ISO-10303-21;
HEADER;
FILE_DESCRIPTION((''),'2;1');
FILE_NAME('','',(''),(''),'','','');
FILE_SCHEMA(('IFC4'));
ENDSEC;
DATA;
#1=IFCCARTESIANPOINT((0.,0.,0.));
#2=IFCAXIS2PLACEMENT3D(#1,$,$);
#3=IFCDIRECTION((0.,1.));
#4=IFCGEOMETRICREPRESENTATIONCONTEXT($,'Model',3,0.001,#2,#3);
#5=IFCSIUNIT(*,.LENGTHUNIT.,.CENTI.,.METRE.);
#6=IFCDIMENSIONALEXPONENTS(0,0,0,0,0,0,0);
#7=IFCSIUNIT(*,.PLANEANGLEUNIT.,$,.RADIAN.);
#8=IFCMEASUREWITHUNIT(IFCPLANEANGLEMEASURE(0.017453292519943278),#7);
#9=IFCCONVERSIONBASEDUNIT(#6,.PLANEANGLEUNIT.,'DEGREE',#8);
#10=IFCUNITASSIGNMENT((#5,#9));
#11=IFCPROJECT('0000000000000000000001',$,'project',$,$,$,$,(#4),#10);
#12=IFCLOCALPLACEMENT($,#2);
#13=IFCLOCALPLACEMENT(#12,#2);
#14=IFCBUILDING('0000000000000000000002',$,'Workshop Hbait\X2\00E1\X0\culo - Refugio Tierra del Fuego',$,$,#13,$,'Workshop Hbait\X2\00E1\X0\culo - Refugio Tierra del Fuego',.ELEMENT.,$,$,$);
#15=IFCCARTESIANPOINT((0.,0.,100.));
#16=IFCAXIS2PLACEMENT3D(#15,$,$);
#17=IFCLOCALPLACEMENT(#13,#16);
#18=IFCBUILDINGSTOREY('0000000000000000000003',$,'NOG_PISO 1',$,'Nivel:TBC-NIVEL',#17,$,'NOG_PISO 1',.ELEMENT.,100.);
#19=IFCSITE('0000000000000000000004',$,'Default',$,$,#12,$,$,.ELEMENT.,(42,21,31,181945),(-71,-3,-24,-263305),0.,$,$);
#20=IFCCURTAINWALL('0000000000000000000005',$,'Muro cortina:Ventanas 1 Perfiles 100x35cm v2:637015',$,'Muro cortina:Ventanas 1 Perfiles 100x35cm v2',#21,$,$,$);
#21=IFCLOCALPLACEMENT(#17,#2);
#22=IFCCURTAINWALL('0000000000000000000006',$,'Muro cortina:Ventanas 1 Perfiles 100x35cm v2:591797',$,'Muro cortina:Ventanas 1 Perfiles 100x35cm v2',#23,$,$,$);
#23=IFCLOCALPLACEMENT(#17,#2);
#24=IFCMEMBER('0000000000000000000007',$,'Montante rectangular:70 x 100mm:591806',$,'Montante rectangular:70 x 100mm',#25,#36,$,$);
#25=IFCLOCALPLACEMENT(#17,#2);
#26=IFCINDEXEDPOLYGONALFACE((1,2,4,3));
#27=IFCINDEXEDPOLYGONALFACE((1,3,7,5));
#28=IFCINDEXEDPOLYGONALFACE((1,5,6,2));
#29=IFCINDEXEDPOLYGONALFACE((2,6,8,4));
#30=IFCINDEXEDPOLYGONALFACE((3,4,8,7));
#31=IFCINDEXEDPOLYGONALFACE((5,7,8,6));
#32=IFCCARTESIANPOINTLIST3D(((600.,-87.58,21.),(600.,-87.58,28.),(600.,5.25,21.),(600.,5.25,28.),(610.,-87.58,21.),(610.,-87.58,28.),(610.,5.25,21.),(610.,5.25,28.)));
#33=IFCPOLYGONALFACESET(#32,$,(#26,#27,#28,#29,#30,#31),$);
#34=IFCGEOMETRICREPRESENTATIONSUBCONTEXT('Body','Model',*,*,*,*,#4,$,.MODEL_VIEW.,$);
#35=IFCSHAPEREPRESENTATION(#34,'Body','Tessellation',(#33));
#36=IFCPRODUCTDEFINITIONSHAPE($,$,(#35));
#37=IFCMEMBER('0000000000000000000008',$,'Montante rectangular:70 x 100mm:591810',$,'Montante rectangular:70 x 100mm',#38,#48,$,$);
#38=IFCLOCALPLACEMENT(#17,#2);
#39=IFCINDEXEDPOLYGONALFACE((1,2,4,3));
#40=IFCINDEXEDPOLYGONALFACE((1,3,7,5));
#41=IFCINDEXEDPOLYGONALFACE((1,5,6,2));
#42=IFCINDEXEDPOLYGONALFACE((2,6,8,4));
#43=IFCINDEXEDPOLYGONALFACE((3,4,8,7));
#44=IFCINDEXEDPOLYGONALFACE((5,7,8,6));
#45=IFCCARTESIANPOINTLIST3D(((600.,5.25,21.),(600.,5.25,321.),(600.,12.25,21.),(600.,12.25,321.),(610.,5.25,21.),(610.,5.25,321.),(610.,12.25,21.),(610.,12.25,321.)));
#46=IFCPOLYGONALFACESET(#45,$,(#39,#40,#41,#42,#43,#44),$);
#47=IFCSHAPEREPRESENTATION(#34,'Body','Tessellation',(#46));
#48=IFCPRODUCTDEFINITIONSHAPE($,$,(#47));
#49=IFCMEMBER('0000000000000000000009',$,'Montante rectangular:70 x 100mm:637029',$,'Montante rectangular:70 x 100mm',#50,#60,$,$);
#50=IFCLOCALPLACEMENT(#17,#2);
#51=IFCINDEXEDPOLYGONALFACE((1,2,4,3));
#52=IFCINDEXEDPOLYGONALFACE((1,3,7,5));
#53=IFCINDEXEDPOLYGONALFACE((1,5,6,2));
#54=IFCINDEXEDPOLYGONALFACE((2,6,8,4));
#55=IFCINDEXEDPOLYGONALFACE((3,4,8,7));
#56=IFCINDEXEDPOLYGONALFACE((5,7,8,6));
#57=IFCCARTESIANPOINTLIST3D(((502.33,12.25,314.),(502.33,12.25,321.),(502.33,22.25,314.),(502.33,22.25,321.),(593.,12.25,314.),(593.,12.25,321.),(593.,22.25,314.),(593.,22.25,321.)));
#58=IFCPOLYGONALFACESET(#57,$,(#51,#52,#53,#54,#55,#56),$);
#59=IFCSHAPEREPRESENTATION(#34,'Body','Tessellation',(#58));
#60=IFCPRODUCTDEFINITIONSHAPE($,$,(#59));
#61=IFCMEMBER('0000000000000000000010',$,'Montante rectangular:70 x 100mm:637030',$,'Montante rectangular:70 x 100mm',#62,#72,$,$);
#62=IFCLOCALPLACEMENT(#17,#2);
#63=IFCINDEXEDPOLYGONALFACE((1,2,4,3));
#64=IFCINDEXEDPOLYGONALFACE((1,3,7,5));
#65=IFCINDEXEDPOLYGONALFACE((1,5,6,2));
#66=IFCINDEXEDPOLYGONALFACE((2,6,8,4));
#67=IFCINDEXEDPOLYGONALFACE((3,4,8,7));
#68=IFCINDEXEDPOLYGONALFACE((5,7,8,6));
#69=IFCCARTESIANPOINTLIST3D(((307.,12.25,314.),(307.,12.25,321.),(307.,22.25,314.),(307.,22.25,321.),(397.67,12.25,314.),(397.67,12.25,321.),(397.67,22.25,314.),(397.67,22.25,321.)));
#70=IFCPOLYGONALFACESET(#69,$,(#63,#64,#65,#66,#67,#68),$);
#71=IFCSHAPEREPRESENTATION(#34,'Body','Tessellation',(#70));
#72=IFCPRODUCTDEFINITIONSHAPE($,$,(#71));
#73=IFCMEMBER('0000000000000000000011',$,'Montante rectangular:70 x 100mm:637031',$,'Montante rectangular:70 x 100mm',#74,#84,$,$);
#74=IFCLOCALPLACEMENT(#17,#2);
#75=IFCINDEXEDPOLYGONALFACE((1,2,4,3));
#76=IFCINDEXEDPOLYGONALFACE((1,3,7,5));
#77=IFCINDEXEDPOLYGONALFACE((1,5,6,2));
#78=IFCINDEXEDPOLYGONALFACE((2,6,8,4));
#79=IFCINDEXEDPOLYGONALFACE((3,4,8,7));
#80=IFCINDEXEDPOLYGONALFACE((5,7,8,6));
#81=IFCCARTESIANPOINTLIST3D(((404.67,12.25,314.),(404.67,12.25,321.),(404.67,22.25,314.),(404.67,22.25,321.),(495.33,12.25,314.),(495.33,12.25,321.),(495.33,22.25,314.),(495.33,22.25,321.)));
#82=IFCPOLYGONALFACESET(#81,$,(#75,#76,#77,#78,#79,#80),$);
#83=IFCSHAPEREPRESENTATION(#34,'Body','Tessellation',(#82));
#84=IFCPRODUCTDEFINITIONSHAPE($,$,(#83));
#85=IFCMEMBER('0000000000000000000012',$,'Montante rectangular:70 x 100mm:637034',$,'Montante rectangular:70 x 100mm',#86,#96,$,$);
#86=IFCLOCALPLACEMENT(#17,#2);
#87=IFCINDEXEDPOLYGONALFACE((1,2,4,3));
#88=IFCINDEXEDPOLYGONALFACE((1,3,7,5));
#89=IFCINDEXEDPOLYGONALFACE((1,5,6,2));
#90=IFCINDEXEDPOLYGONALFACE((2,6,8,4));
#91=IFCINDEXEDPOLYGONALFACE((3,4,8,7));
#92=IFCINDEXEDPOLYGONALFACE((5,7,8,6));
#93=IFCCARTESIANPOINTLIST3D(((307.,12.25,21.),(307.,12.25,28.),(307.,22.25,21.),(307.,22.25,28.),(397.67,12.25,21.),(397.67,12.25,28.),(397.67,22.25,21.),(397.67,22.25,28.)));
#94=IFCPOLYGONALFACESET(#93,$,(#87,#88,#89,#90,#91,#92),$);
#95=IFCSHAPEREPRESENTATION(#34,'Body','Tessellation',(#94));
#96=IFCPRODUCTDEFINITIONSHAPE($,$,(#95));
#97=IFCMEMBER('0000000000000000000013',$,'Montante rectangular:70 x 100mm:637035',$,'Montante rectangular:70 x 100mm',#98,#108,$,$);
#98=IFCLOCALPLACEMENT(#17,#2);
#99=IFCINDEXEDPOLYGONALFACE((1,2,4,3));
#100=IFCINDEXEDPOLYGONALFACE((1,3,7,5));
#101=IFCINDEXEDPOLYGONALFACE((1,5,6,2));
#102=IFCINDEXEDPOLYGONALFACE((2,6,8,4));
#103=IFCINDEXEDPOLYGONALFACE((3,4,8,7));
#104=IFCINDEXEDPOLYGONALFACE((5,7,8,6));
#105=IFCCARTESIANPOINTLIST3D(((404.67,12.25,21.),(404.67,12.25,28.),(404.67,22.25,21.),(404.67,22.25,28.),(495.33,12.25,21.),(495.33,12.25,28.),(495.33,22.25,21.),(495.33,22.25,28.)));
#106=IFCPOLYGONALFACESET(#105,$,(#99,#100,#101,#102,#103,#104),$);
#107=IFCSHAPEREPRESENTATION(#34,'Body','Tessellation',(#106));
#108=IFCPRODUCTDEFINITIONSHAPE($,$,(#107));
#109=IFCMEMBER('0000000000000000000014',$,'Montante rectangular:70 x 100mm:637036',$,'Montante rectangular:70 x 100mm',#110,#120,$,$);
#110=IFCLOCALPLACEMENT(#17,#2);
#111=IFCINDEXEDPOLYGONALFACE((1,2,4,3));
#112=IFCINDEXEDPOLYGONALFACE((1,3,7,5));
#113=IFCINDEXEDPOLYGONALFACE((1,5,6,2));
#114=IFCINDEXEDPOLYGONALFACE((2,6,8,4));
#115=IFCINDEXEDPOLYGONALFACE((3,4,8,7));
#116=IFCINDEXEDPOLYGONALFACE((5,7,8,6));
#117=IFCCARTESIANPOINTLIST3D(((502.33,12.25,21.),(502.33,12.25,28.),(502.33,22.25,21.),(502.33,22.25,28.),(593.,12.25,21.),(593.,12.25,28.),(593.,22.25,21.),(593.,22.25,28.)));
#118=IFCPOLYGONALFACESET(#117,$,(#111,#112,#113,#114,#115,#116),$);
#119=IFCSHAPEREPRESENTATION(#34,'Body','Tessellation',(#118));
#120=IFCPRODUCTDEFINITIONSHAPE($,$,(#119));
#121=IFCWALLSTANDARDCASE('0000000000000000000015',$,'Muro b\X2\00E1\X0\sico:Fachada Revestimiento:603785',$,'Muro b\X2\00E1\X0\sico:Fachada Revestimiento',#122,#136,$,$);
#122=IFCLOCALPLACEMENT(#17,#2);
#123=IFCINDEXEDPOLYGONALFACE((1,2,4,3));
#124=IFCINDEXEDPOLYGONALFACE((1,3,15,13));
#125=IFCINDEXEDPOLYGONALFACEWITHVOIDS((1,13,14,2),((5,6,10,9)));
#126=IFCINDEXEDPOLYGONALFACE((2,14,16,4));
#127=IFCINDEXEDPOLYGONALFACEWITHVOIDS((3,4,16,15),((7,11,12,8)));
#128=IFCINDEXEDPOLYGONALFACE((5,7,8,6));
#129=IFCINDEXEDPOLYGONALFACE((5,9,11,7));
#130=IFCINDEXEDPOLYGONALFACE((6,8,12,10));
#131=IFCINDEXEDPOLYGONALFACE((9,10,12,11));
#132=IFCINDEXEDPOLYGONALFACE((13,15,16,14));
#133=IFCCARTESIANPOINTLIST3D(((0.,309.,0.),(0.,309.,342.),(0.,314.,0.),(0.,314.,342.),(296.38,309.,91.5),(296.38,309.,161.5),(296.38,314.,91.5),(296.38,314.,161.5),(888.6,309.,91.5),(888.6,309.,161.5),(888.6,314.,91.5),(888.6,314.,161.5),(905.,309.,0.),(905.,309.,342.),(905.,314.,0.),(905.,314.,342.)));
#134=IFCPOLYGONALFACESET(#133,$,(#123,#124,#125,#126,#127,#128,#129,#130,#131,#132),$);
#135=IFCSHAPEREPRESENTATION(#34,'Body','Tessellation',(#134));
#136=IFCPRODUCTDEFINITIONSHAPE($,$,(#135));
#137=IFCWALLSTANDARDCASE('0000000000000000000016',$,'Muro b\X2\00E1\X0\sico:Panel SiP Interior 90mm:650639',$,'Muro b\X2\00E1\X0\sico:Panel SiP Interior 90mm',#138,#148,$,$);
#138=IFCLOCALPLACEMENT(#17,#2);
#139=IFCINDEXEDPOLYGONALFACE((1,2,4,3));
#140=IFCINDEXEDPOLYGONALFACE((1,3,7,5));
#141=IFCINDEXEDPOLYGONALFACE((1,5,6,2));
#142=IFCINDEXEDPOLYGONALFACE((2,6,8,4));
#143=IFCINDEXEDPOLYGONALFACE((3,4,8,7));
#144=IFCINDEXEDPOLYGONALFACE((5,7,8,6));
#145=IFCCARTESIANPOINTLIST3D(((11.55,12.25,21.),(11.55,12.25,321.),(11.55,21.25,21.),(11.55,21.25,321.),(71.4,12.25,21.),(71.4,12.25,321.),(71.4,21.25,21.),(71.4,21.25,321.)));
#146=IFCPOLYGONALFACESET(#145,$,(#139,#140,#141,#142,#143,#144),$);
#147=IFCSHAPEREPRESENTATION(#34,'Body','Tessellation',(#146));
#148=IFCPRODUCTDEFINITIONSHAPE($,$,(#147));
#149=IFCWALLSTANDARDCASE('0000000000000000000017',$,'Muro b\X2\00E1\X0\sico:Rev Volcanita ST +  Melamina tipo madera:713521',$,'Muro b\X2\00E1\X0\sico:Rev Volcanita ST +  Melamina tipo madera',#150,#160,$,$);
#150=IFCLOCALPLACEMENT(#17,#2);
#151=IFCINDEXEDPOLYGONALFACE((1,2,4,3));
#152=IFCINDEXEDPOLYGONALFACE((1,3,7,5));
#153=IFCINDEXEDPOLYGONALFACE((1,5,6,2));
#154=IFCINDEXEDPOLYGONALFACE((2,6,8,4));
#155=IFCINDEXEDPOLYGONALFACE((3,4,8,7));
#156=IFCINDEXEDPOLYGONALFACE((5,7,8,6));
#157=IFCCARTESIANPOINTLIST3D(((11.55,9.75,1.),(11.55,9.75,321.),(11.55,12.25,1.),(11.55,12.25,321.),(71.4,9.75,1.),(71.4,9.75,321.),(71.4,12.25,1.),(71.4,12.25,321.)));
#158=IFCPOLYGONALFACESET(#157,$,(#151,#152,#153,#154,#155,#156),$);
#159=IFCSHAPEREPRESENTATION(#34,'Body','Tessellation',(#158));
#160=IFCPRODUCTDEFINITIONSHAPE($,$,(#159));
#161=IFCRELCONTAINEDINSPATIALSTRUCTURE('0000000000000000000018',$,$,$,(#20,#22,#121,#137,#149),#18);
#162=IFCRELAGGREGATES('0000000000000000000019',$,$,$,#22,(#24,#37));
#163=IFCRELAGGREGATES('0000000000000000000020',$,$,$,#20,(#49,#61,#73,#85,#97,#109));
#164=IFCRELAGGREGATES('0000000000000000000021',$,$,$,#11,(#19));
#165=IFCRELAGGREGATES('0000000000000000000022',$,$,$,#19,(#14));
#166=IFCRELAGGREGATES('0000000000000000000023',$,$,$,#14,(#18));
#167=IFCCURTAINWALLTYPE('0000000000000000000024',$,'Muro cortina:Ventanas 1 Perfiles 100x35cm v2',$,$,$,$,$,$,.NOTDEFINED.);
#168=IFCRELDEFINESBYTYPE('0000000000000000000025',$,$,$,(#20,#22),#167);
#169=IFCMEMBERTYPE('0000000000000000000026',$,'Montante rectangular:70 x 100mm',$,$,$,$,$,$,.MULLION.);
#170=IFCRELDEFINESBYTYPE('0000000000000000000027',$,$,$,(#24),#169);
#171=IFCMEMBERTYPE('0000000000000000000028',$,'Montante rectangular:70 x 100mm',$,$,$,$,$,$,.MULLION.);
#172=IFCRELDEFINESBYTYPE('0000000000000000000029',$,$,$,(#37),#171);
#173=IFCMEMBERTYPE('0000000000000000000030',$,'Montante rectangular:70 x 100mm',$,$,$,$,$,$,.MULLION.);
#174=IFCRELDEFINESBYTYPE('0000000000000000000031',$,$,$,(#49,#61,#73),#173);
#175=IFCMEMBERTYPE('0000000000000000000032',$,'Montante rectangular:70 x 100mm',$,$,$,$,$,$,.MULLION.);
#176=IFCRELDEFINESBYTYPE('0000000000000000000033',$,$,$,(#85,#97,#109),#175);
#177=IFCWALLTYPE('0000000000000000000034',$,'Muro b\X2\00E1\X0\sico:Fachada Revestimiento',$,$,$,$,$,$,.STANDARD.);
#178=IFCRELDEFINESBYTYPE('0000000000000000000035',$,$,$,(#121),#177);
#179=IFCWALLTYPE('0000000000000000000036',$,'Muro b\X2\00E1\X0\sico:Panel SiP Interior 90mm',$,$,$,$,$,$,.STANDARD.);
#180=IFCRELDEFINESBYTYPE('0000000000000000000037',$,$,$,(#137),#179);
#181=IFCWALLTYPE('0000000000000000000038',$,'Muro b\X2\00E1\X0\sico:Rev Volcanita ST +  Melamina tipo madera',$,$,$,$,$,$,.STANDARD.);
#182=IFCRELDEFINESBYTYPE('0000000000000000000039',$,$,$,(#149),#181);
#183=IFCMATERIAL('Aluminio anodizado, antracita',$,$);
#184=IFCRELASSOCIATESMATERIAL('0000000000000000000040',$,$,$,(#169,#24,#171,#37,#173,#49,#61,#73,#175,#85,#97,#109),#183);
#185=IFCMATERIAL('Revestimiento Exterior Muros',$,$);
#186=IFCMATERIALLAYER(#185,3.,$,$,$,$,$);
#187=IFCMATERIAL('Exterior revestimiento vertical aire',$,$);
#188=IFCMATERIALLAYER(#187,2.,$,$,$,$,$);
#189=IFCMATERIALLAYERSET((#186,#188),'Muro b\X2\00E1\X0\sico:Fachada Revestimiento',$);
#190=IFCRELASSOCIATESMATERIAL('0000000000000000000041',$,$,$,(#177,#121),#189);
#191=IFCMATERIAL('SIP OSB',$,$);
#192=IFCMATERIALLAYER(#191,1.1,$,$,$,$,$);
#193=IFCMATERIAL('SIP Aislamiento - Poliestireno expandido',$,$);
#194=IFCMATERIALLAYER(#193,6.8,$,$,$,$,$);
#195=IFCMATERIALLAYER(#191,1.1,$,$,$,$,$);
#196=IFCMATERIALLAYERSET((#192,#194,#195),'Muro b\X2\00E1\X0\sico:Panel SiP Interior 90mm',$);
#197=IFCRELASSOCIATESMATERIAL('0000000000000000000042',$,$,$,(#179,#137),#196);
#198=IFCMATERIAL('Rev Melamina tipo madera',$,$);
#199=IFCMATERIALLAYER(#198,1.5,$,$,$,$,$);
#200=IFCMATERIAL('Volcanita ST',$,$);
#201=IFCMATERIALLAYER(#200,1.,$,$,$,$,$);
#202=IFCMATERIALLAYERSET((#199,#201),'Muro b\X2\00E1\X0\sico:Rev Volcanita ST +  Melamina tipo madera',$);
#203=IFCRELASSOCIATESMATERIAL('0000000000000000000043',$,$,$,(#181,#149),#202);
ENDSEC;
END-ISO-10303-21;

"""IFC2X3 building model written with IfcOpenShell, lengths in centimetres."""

from ifc_helpers import new_model, entity, si_unit, converted_unit, direction, frame, frame_2d, origin, origin_2d_with_axis, place, context, subcontext, project, spatial, rectangle, extrude, source, transform, mapped, material, layer, layer_set, layer_usage, type_object, type_shapes, element, aggregate, save


model = new_model("IFC2X3")

# Units and contexts
model_context = context("Model", 3, precision=0.001, world=origin(), true_north=direction((0.0, 1.0)))
body_context = subcontext(model_context, "Body", "Model", "MODEL_VIEW")
ifc_project = project(units=[si_unit("LENGTHUNIT", "METRE", prefix="CENTI"), converted_unit("PLANEANGLEUNIT", "DEGREE", entity("IfcPlaneAngleMeasure", 0.017453292519943278), si_unit("PLANEANGLEUNIT", "RADIAN"), dimensions=[0, 0, 0, 0, 0, 0, 0])], contexts=[model_context])

# Site, building, storey
site_placement = place(None, origin())
site = spatial("IfcSite", under=ifc_project, at=site_placement, Name="Default", CompositionType="ELEMENT", RefLatitude=(42, 21, 31, 181945), RefLongitude=(-71, -3, -24, -263305), RefElevation=0.0)
building_placement = place(site_placement, origin())
building = spatial("IfcBuilding", under=site, at=building_placement, Name="Workshop Hbaitáculo - Refugio Tierra del Fuego", LongName="Workshop Hbaitáculo - Refugio Tierra del Fuego", CompositionType="ELEMENT")
storey_placement = place(building_placement, frame((0.0, 0.0, 100.0)))
storey = spatial("IfcBuildingStorey", under=building, at=storey_placement, Name="NOG_PISO 1", ObjectType="Nivel:TBC-NIVEL", LongName="NOG_PISO 1", CompositionType="ELEMENT", Elevation=100.0)

# Curtain wall
curtain_wall_type = type_object("IfcCurtainWallType", Name="Muro cortina:Ventanas 1 Perfiles 100x35cm v2", PredefinedType="NOTDEFINED")
ifc_material_1 = material(Name="Aluminio anodizado, antracita")
curtain_wall_1_placement = place(storey_placement, frame((0.0, 0.0, -100.0)))
curtain_wall_1 = element("IfcCurtainWall", 1, at=curtain_wall_1_placement, inside=storey, type_object=curtain_wall_type, Name="Muro cortina:Ventanas 1 Perfiles 100x35cm v2:637015", ObjectType="Muro cortina:Ventanas 1 Perfiles 100x35cm v2")

# Curtain wall, members
curtain_wall_2_placement = place(storey_placement, frame((0.0, 0.0, -100.0)))
curtain_wall_2 = element("IfcCurtainWall", 2, at=curtain_wall_2_placement, inside=storey, type_object=curtain_wall_type, Name="Muro cortina:Ventanas 1 Perfiles 100x35cm v2:591797", ObjectType="Muro cortina:Ventanas 1 Perfiles 100x35cm v2")
member_type_1 = type_object("IfcMemberType", Name="Montante rectangular:70 x 100mm", PredefinedType="MULLION", material=ifc_material_1)
shared_shape_1 = source(origin(), body_context, "Body", "SweptSolid", [
    extrude(rectangle(XDim=7.0, YDim=10.0, at=origin_2d_with_axis()), frame((-3.5, 0.0, -92.83), z_axis=(0.0, 0.0, 1.0), x_axis=(-1.0, 0.0, 0.0)), (0.0, 0.0, 1.0), 92.83),
])
type_shapes(member_type_1, [shared_shape_1])
member_1_placement = place(curtain_wall_2_placement, frame((605.0, 5.25, 121.0), z_axis=(0.0, 1.0, 0.0), x_axis=(0.0, 0.0, -1.0)))
member_1 = element("IfcMember", 3, at=member_1_placement, type_object=member_type_1, material=ifc_material_1, Name="Montante rectangular:70 x 100mm:591806", ObjectType="Montante rectangular:70 x 100mm", context=body_context, shape_type="MappedRepresentation", body=[
    mapped(shared_shape_1, transform((0.0, 0.0, 0.0), scale=1.0)),
])
member_type_2 = type_object("IfcMemberType", Name="Montante rectangular:70 x 100mm", PredefinedType="MULLION", material=ifc_material_1)
shared_shape_2 = source(origin(), body_context, "Body", "SweptSolid", [
    extrude(rectangle(XDim=7.0, YDim=10.0, at=origin_2d_with_axis()), frame((-3.5, 0.0, -300.0), z_axis=(0.0, 0.0, 1.0), x_axis=(-1.0, 0.0, 0.0)), (0.0, 0.0, 1.0), 300.0),
])
type_shapes(member_type_2, [shared_shape_2])
member_2_placement = place(curtain_wall_2_placement, frame((605.0, 12.25, 421.0), z_axis=(0.0, 0.0, 1.0), x_axis=(0.0, 1.0, 0.0)))
member_2 = element("IfcMember", 4, at=member_2_placement, type_object=member_type_2, material=ifc_material_1, Name="Montante rectangular:70 x 100mm:591810", ObjectType="Montante rectangular:70 x 100mm", context=body_context, shape_type="MappedRepresentation", body=[
    mapped(shared_shape_2, transform((0.0, 0.0, 0.0), scale=1.0)),
])

# Members
member_type_3 = type_object("IfcMemberType", Name="Montante rectangular:70 x 100mm", PredefinedType="MULLION", material=ifc_material_1)
shared_shape_3 = source(origin(), body_context, "Body", "SweptSolid", [
    extrude(rectangle(XDim=7.0, YDim=10.0, at=origin_2d_with_axis()), frame((-3.5, 0.0, -90.67), z_axis=(0.0, 0.0, 1.0), x_axis=(-1.0, 0.0, 0.0)), (0.0, 0.0, 1.0), 90.67),
])
type_shapes(member_type_3, [shared_shape_3])
member_3_placement = place(curtain_wall_1_placement, frame((593.0, 17.25, 421.0), z_axis=(1.0, 0.0, 0.0), x_axis=(0.0, 0.0, 1.0)))
member_3 = element("IfcMember", 5, at=member_3_placement, type_object=member_type_3, material=ifc_material_1, Name="Montante rectangular:70 x 100mm:637029", ObjectType="Montante rectangular:70 x 100mm", context=body_context, shape_type="MappedRepresentation", body=[
    mapped(shared_shape_3, transform((0.0, 0.0, 0.0), scale=1.0)),
])
member_4_placement = place(curtain_wall_1_placement, frame((397.67, 17.25, 421.0), z_axis=(1.0, 0.0, 0.0), x_axis=(0.0, 0.0, 1.0)))
member_4 = element("IfcMember", 6, at=member_4_placement, type_object=member_type_3, material=ifc_material_1, Name="Montante rectangular:70 x 100mm:637030", ObjectType="Montante rectangular:70 x 100mm", context=body_context, shape_type="MappedRepresentation", body=[
    mapped(shared_shape_3, transform((0.0, 0.0, 0.0), scale=1.0)),
])
member_5_placement = place(curtain_wall_1_placement, frame((495.33, 17.25, 421.0), z_axis=(1.0, 0.0, 0.0), x_axis=(0.0, 0.0, 1.0)))
member_5 = element("IfcMember", 7, at=member_5_placement, type_object=member_type_3, material=ifc_material_1, Name="Montante rectangular:70 x 100mm:637031", ObjectType="Montante rectangular:70 x 100mm", context=body_context, shape_type="MappedRepresentation", body=[
    mapped(shared_shape_3, transform((0.0, 0.0, 0.0), scale=1.0)),
])
member_type_4 = type_object("IfcMemberType", Name="Montante rectangular:70 x 100mm", PredefinedType="MULLION", material=ifc_material_1)
shared_shape_4 = source(origin(), body_context, "Body", "SweptSolid", [
    extrude(rectangle(XDim=7.0, YDim=10.0, at=origin_2d_with_axis()), frame((-3.5, 0.0, -90.67), z_axis=(0.0, 0.0, 1.0), x_axis=(-1.0, 0.0, 0.0)), (0.0, 0.0, 1.0), 90.67),
])
type_shapes(member_type_4, [shared_shape_4])
member_6_placement = place(curtain_wall_1_placement, frame((307.0, 17.25, 121.0), z_axis=(-1.0, 0.0, 0.0), x_axis=(0.0, 0.0, -1.0)))
member_6 = element("IfcMember", 8, at=member_6_placement, type_object=member_type_4, material=ifc_material_1, Name="Montante rectangular:70 x 100mm:637034", ObjectType="Montante rectangular:70 x 100mm", context=body_context, shape_type="MappedRepresentation", body=[
    mapped(shared_shape_4, transform((0.0, 0.0, 0.0), scale=1.0)),
])
member_7_placement = place(curtain_wall_1_placement, frame((404.67, 17.25, 121.0), z_axis=(-1.0, 0.0, 0.0), x_axis=(0.0, 0.0, -1.0)))
member_7 = element("IfcMember", 9, at=member_7_placement, type_object=member_type_4, material=ifc_material_1, Name="Montante rectangular:70 x 100mm:637035", ObjectType="Montante rectangular:70 x 100mm", context=body_context, shape_type="MappedRepresentation", body=[
    mapped(shared_shape_4, transform((0.0, 0.0, 0.0), scale=1.0)),
])
member_8_placement = place(curtain_wall_1_placement, frame((502.33, 17.25, 121.0), z_axis=(-1.0, 0.0, 0.0), x_axis=(0.0, 0.0, -1.0)))
member_8 = element("IfcMember", 10, at=member_8_placement, type_object=member_type_4, material=ifc_material_1, Name="Montante rectangular:70 x 100mm:637036", ObjectType="Montante rectangular:70 x 100mm", context=body_context, shape_type="MappedRepresentation", body=[
    mapped(shared_shape_4, transform((0.0, 0.0, 0.0), scale=1.0)),
])

aggregate(curtain_wall_2, [member_1, member_2])
aggregate(curtain_wall_1, [member_3, member_4, member_5, member_6, member_7, member_8])

# Wall, opening
ifc_material_2 = material(Name="Revestimiento Exterior Muros")
ifc_layer_1 = layer(ifc_material_2, 3.0)
ifc_material_3 = material(Name="Exterior revestimiento vertical aire")
ifc_layer_2 = layer(ifc_material_3, 2.0)
ifc_layer_set_1 = layer_set([ifc_layer_1, ifc_layer_2], Name="Muro básico:Fachada Revestimiento")
ifc_layer_usage_1 = layer_usage(ifc_layer_set_1, "AXIS2", "POSITIVE", -2.5)
wall_type_1 = type_object("IfcWallType", Name="Muro básico:Fachada Revestimiento", PredefinedType="STANDARD", material=ifc_layer_set_1)
wall_1_placement = place(storey_placement, frame((905.0, 311.5, 0.0), z_axis=(0.0, 0.0, 1.0), x_axis=(-1.0, 0.0, 0.0)))
wall_1 = element("IfcWallStandardCase", 11, at=wall_1_placement, inside=storey, type_object=wall_type_1, material=ifc_layer_usage_1, Name="Muro básico:Fachada Revestimiento:603785", ObjectType="Muro básico:Fachada Revestimiento", context=body_context, shape_type="SweptSolid", body=[
    extrude(rectangle(XDim=905.0, YDim=5.0, at=frame_2d((452.5, 0.0), x_axis=(-1.0, 0.0))), origin(), (0.0, 0.0, 1.0), 342.0),
])
opening_placement = place(wall_1_placement, origin())
element("IfcOpeningElement", 12, at=opening_placement, cuts=wall_1, ObjectType="Opening", context=body_context, shape_type="SweptSolid", body=[
    extrude(rectangle(XDim=70.0, YDim=592.22, at=frame_2d((0.0, 0.0), x_axis=(1.0, 0.0))), frame((312.51, 2.5, 126.5), z_axis=(0.0, -1.0, 0.0), x_axis=(0.0, 0.0, -1.0)), (0.0, 0.0, 1.0), 5.0),
])

# Walls
ifc_material_4 = material(Name="SIP OSB")
ifc_layer_3 = layer(ifc_material_4, 1.1)
ifc_material_5 = material(Name="SIP Aislamiento - Poliestireno expandido")
ifc_layer_4 = layer(ifc_material_5, 6.8)
ifc_layer_5 = layer(ifc_material_4, 1.1)
ifc_layer_set_2 = layer_set([ifc_layer_3, ifc_layer_4, ifc_layer_5], Name="Muro básico:Panel SiP Interior 90mm")
ifc_layer_usage_2 = layer_usage(ifc_layer_set_2, "AXIS2", "POSITIVE", -4.5)
wall_type_2 = type_object("IfcWallType", Name="Muro básico:Panel SiP Interior 90mm", PredefinedType="STANDARD", material=ifc_layer_set_2)
wall_2_placement = place(storey_placement, frame((71.4, 16.75, 21.0), z_axis=(0.0, 0.0, 1.0), x_axis=(-1.0, 0.0, 0.0)))
element("IfcWallStandardCase", 13, at=wall_2_placement, inside=storey, type_object=wall_type_2, material=ifc_layer_usage_2, Name="Muro básico:Panel SiP Interior 90mm:650639", ObjectType="Muro básico:Panel SiP Interior 90mm", context=body_context, shape_type="SweptSolid", body=[
    extrude(rectangle(XDim=59.85, YDim=9.0, at=frame_2d((29.93, 0.0), x_axis=(-1.0, 0.0))), origin(), (0.0, 0.0, 1.0), 300.0),
])
ifc_material_6 = material(Name="Rev Melamina tipo madera")
ifc_layer_6 = layer(ifc_material_6, 1.5)
ifc_material_7 = material(Name="Volcanita ST")
ifc_layer_7 = layer(ifc_material_7, 1.0)
ifc_layer_set_3 = layer_set([ifc_layer_6, ifc_layer_7], Name="Muro básico:Rev Volcanita ST +  Melamina tipo madera")
ifc_layer_usage_3 = layer_usage(ifc_layer_set_3, "AXIS2", "POSITIVE", -1.25)
wall_type_3 = type_object("IfcWallType", Name="Muro básico:Rev Volcanita ST +  Melamina tipo madera", PredefinedType="STANDARD", material=ifc_layer_set_3)
wall_3_placement = place(storey_placement, frame((11.55, 11.0, 1.0)))
element("IfcWallStandardCase", 14, at=wall_3_placement, inside=storey, type_object=wall_type_3, material=ifc_layer_usage_3, Name="Muro básico:Rev Volcanita ST +  Melamina tipo madera:713521", ObjectType="Muro básico:Rev Volcanita ST +  Melamina tipo madera", context=body_context, shape_type="SweptSolid", body=[
    extrude(rectangle(XDim=59.85, YDim=2.5, at=frame_2d((29.93, 0.0), x_axis=(-1.0, 0.0))), origin(), (0.0, 0.0, 1.0), 320.0),
])

save(model, "model.ifc")
